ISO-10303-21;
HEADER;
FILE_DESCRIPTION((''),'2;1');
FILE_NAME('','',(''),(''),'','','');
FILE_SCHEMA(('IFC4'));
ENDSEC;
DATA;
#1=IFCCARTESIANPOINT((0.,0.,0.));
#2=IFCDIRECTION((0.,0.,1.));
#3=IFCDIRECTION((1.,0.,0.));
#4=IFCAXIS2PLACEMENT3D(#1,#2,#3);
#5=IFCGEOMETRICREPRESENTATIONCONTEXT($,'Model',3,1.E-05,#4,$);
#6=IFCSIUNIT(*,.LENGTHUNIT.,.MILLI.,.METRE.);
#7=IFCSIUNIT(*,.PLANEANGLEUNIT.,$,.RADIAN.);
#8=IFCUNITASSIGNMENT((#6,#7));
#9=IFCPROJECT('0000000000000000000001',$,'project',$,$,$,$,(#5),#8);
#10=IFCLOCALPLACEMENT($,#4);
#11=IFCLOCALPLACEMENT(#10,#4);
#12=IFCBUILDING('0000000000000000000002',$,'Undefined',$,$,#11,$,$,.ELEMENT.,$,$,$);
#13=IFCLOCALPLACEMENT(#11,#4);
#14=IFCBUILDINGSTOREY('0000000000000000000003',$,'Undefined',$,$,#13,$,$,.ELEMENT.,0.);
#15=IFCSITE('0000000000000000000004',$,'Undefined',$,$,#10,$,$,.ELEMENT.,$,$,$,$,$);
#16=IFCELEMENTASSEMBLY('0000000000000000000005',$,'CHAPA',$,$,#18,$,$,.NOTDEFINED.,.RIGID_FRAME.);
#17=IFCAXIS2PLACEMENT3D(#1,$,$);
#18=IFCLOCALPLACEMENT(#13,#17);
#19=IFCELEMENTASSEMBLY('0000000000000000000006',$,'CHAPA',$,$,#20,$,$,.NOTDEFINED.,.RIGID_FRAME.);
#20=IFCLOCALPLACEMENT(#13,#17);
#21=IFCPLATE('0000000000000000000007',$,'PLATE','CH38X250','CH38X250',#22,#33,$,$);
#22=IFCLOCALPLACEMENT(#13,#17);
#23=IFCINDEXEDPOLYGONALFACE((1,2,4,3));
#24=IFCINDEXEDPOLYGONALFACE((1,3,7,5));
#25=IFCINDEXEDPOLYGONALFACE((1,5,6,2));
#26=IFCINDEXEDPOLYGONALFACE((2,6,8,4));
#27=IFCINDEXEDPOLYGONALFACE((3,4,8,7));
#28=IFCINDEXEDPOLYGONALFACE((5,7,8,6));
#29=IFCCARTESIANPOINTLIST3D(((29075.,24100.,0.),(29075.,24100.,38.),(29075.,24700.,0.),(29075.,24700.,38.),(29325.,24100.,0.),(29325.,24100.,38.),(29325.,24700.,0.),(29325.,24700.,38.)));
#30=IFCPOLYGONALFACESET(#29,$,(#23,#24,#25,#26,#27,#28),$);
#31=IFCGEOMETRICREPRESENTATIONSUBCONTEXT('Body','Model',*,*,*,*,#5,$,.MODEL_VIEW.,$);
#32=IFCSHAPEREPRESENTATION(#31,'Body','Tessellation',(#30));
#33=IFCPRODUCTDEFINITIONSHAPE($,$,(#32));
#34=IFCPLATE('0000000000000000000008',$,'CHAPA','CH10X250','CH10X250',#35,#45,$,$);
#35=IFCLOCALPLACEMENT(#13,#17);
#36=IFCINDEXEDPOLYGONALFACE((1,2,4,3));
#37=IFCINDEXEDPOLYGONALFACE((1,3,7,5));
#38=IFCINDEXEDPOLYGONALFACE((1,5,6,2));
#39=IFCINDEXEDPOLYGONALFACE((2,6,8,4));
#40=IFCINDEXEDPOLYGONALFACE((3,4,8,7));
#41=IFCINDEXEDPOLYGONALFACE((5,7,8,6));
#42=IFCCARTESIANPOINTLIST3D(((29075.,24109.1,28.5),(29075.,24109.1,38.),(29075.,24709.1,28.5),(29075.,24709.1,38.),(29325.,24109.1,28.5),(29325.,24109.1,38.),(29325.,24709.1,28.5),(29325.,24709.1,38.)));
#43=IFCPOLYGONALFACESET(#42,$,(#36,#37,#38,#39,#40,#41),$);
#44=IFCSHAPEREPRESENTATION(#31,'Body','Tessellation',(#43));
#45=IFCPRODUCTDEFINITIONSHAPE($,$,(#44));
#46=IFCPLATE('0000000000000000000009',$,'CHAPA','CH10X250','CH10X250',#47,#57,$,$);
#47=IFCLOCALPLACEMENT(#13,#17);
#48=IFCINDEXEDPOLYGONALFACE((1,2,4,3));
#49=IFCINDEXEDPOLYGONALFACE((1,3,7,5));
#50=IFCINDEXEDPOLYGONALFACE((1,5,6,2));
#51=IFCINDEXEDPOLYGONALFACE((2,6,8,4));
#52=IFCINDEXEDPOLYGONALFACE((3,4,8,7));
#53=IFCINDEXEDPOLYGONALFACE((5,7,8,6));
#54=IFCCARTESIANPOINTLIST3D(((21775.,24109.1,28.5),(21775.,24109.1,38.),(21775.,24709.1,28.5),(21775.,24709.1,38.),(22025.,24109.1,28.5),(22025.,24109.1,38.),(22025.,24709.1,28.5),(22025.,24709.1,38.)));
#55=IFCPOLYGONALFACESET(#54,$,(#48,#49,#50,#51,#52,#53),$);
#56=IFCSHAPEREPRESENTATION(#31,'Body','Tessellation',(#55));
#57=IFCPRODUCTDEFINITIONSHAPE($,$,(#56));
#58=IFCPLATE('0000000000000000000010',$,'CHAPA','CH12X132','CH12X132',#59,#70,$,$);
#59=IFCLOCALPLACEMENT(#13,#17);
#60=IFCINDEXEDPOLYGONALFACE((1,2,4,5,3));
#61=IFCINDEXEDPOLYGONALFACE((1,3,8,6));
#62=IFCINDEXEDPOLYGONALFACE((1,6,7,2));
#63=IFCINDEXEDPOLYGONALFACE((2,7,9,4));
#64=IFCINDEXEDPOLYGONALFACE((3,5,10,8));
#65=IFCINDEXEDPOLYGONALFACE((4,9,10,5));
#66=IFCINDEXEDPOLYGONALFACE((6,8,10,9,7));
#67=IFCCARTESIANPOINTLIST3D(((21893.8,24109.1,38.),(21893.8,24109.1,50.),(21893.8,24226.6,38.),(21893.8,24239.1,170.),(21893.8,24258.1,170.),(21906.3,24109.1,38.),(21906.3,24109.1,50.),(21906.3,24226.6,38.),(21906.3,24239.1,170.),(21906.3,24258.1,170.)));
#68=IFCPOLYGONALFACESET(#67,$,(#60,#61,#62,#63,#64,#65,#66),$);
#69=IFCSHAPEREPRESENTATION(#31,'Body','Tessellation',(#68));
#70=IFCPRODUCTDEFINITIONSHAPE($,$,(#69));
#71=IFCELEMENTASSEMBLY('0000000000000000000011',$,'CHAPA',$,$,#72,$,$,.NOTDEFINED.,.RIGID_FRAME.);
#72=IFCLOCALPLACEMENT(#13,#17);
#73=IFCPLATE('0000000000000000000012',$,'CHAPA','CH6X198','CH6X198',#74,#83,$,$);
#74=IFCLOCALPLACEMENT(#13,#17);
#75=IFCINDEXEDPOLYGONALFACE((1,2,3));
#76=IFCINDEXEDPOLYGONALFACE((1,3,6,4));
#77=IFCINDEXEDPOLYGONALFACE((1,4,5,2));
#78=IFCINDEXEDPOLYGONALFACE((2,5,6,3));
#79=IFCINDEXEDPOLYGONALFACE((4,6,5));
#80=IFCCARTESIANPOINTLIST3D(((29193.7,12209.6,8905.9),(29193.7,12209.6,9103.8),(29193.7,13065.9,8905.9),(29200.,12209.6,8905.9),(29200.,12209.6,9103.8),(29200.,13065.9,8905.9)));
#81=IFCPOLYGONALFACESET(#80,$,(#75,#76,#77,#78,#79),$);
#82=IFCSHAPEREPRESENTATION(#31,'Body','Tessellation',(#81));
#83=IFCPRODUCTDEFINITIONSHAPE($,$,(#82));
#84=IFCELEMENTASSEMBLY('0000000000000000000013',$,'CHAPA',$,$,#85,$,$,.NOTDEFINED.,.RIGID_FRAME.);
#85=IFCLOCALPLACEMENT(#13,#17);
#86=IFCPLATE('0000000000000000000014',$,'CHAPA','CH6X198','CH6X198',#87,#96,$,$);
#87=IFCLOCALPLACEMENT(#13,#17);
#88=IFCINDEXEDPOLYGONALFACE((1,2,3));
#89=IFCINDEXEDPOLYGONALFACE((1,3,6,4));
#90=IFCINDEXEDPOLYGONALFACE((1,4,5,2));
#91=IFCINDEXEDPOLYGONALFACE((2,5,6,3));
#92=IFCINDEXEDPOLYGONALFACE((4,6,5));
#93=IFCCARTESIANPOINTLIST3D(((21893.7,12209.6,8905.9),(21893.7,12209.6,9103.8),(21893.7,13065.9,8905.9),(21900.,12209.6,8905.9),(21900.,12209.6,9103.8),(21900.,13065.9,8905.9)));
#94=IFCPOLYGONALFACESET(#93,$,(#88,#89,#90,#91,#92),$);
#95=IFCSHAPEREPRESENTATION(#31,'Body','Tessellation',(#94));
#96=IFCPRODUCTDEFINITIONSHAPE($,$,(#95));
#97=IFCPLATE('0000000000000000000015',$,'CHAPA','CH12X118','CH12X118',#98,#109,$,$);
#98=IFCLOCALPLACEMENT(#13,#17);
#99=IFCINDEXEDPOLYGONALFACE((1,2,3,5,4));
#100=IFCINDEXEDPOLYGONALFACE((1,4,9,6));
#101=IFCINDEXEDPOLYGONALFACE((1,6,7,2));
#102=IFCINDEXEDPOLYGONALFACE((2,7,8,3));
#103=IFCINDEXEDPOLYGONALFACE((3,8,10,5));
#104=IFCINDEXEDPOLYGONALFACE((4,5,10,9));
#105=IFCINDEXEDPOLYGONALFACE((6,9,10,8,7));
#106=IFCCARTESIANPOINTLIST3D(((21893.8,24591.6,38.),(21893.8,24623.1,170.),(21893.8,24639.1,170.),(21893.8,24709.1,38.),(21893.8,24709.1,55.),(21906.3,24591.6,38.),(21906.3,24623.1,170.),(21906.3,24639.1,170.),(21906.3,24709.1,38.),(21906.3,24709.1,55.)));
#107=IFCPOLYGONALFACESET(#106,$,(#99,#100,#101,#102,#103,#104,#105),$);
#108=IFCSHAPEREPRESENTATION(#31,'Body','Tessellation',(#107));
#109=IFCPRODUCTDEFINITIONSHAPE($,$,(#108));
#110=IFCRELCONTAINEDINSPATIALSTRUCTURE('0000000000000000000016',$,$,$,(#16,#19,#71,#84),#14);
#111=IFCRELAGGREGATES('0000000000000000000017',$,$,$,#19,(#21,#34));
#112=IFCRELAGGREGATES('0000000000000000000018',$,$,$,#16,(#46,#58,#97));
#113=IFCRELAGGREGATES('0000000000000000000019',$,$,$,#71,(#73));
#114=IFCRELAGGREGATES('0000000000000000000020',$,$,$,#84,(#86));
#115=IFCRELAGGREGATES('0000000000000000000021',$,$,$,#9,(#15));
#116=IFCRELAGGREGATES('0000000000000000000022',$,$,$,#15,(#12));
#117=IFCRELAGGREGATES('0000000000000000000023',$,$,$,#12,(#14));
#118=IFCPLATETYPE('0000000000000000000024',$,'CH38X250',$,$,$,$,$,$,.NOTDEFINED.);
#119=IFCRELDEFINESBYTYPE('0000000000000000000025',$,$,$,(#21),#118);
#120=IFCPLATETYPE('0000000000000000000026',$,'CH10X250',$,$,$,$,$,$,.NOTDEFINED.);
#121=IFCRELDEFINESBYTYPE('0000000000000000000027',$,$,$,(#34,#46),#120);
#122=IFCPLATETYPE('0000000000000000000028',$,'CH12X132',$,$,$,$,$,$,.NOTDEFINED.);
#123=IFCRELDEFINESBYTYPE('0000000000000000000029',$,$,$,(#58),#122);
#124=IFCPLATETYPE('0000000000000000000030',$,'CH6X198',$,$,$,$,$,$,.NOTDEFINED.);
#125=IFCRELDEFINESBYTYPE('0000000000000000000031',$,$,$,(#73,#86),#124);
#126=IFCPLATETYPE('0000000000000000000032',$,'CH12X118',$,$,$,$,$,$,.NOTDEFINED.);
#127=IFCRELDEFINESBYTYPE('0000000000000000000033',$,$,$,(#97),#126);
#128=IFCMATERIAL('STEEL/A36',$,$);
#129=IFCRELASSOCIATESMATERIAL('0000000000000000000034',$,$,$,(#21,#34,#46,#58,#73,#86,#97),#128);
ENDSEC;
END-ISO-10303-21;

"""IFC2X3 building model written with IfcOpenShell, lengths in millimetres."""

from ifc_helpers import new_model, si_unit, frame, origin_with_axes, place, context, subcontext, project, spatial, polyline, outline, extrude, material, type_object, element, aggregate, save


model = new_model("IFC2X3")

# Units and contexts
model_context = context("Model", 3, precision=1e-05, world=origin_with_axes())
body_context = subcontext(model_context, "Body", "Model", "MODEL_VIEW")
ifc_project = project(units=[si_unit("LENGTHUNIT", "METRE", prefix="MILLI"), si_unit("PLANEANGLEUNIT", "RADIAN")], contexts=[model_context])

# Site, building, storey
site_placement = place(None, origin_with_axes())
site = spatial("IfcSite", under=ifc_project, at=site_placement, Name="Undefined", CompositionType="ELEMENT")
building_placement = place(site_placement, origin_with_axes())
building = spatial("IfcBuilding", under=site, at=building_placement, Name="Undefined", CompositionType="ELEMENT")
storey_placement = place(building_placement, origin_with_axes())
storey = spatial("IfcBuildingStorey", under=building, at=storey_placement, Name="Undefined", CompositionType="ELEMENT", Elevation=0.0)

# Element assembly
assembly_1_placement = place(storey_placement, origin_with_axes())
assembly_1 = element("IfcElementAssembly", 1, at=assembly_1_placement, inside=storey, Name="CHAPA", AssemblyPlace="NOTDEFINED", PredefinedType="RIGID_FRAME")

# Element assembly, plates
assembly_2_placement = place(storey_placement, origin_with_axes())
assembly_2 = element("IfcElementAssembly", 2, at=assembly_2_placement, inside=storey, Name="CHAPA", AssemblyPlace="NOTDEFINED", PredefinedType="RIGID_FRAME")
ifc_material_1 = material(Name="STEEL/A36")
plate_type_1 = type_object("IfcPlateType", Name="CH38X250", PredefinedType="NOTDEFINED")
plate_1_placement = place(assembly_2_placement, frame((29075.0, 24700.0, 19.0), z_axis=(0.0, 0.0, 1.0), x_axis=(0.0, -1.0, 0.0)))
plate_1 = element("IfcPlate", 3, at=plate_1_placement, type_object=plate_type_1, material=ifc_material_1, Name="PLATE", Description="CH38X250", ObjectType="CH38X250", context=body_context, shape_type="SweptSolid", body=[
    extrude(outline(polyline([(0.0, 0.0), (600.0, 0.0), (600.0, 250.0), (0.0, 250.0), (0.0, 0.0)])), frame((0.0, 0.0, -19.0), z_axis=(0.0, 0.0, 1.0), x_axis=(1.0, 0.0, 0.0)), (0.0, 0.0, 1.0), 38.0),
])
plate_type_2 = type_object("IfcPlateType", Name="CH10X250", PredefinedType="NOTDEFINED")
plate_2_placement = place(assembly_2_placement, frame((29075.0, 24709.1, 33.2), z_axis=(0.0, 0.0, -1.0), x_axis=(1.0, 0.0, 0.0)))
plate_2 = element("IfcPlate", 4, at=plate_2_placement, type_object=plate_type_2, material=ifc_material_1, Name="CHAPA", Description="CH10X250", ObjectType="CH10X250", context=body_context, shape_type="SweptSolid", body=[
    extrude(outline(polyline([(0.0, 0.0), (250.0, 0.0), (250.0, 600.0), (0.0, 600.0), (0.0, 0.0)])), frame((0.0, 0.0, -4.8), z_axis=(0.0, 0.0, 1.0), x_axis=(1.0, 0.0, 0.0)), (0.0, 0.0, 1.0), 9.5),
])
aggregate(assembly_2, [plate_1, plate_2])

# Plates
plate_3_placement = place(assembly_1_placement, frame((21775.0, 24709.1, 33.2), z_axis=(0.0, 0.0, -1.0), x_axis=(1.0, 0.0, 0.0)))
plate_3 = element("IfcPlate", 5, at=plate_3_placement, type_object=plate_type_2, material=ifc_material_1, Name="CHAPA", Description="CH10X250", ObjectType="CH10X250", context=body_context, shape_type="SweptSolid", body=[
    extrude(outline(polyline([(0.0, 0.0), (250.0, 0.0), (250.0, 600.0), (0.0, 600.0), (0.0, 0.0)])), frame((0.0, 0.0, -4.8), z_axis=(0.0, 0.0, 1.0), x_axis=(1.0, 0.0, 0.0)), (0.0, 0.0, 1.0), 9.5),
])
plate_type_3 = type_object("IfcPlateType", Name="CH12X132", PredefinedType="NOTDEFINED")
plate_4_placement = place(assembly_1_placement, frame((21900.0, 24226.6, 38.0), z_axis=(-1.0, 0.0, 0.0), x_axis=(0.0, -1.0, 0.0)))
plate_4 = element("IfcPlate", 6, at=plate_4_placement, type_object=plate_type_3, material=ifc_material_1, Name="CHAPA", Description="CH12X132", ObjectType="CH12X132", context=body_context, shape_type="SweptSolid", body=[
    extrude(outline(polyline([(0.0, 0.0), (117.5, 0.0), (117.5, 12.0), (-12.5, 132.0), (-31.6, 132.0), (0.0, 0.0)])), frame((0.0, 0.0, -6.2), z_axis=(0.0, 0.0, 1.0), x_axis=(1.0, 0.0, 0.0)), (0.0, 0.0, 1.0), 12.5),
])

# Element assemblies, plates
assembly_3_placement = place(storey_placement, origin_with_axes())
assembly_3 = element("IfcElementAssembly", 7, at=assembly_3_placement, inside=storey, Name="CHAPA", AssemblyPlace="NOTDEFINED", PredefinedType="RIGID_FRAME")
plate_type_4 = type_object("IfcPlateType", Name="CH6X198", PredefinedType="NOTDEFINED")
plate_5_placement = place(assembly_3_placement, frame((29196.8, 13065.9, 8905.9), z_axis=(-1.0, 0.0, 0.0), x_axis=(0.0, -1.0, 0.0)))
plate_5 = element("IfcPlate", 8, at=plate_5_placement, type_object=plate_type_4, material=ifc_material_1, Name="CHAPA", Description="CH6X198", ObjectType="CH6X198", context=body_context, shape_type="SweptSolid", body=[
    extrude(outline(polyline([(0.0, 0.0), (856.3, 0.0), (856.3, 197.9), (0.0, 0.0)])), frame((0.0, 0.0, -3.1), z_axis=(0.0, 0.0, 1.0), x_axis=(1.0, 0.0, 0.0)), (0.0, 0.0, 1.0), 6.3),
])
assembly_4_placement = place(storey_placement, origin_with_axes())
assembly_4 = element("IfcElementAssembly", 9, at=assembly_4_placement, inside=storey, Name="CHAPA", AssemblyPlace="NOTDEFINED", PredefinedType="RIGID_FRAME")
plate_6_placement = place(assembly_4_placement, frame((21896.8, 13065.9, 8905.9), z_axis=(-1.0, 0.0, 0.0), x_axis=(0.0, -1.0, 0.0)))
plate_6 = element("IfcPlate", 10, at=plate_6_placement, type_object=plate_type_4, material=ifc_material_1, Name="CHAPA", Description="CH6X198", ObjectType="CH6X198", context=body_context, shape_type="SweptSolid", body=[
    extrude(outline(polyline([(0.0, 0.0), (856.3, 0.0), (856.3, 197.9), (0.0, 0.0)])), frame((0.0, 0.0, -3.1), z_axis=(0.0, 0.0, 1.0), x_axis=(1.0, 0.0, 0.0)), (0.0, 0.0, 1.0), 6.3),
])

# Plate
plate_type_5 = type_object("IfcPlateType", Name="CH12X118", PredefinedType="NOTDEFINED")
plate_7_placement = place(assembly_1_placement, frame((21900.0, 24709.1, 38.0), z_axis=(-1.0, 0.0, 0.0), x_axis=(0.0, -1.0, 0.0)))
plate_7 = element("IfcPlate", 11, at=plate_7_placement, type_object=plate_type_5, material=ifc_material_1, Name="CHAPA", Description="CH12X118", ObjectType="CH12X118", context=body_context, shape_type="SweptSolid", body=[
    extrude(outline(polyline([(0.0, 0.0), (117.5, 0.0), (85.9, 132.0), (70.0, 132.0), (0.0, 17.0), (0.0, 0.0)])), frame((0.0, 0.0, -6.2), z_axis=(0.0, 0.0, 1.0), x_axis=(1.0, 0.0, 0.0)), (0.0, 0.0, 1.0), 12.5),
])

aggregate(assembly_1, [plate_3, plate_4, plate_7])
aggregate(assembly_3, [plate_5])
aggregate(assembly_4, [plate_6])

save(model, "model.ifc")
